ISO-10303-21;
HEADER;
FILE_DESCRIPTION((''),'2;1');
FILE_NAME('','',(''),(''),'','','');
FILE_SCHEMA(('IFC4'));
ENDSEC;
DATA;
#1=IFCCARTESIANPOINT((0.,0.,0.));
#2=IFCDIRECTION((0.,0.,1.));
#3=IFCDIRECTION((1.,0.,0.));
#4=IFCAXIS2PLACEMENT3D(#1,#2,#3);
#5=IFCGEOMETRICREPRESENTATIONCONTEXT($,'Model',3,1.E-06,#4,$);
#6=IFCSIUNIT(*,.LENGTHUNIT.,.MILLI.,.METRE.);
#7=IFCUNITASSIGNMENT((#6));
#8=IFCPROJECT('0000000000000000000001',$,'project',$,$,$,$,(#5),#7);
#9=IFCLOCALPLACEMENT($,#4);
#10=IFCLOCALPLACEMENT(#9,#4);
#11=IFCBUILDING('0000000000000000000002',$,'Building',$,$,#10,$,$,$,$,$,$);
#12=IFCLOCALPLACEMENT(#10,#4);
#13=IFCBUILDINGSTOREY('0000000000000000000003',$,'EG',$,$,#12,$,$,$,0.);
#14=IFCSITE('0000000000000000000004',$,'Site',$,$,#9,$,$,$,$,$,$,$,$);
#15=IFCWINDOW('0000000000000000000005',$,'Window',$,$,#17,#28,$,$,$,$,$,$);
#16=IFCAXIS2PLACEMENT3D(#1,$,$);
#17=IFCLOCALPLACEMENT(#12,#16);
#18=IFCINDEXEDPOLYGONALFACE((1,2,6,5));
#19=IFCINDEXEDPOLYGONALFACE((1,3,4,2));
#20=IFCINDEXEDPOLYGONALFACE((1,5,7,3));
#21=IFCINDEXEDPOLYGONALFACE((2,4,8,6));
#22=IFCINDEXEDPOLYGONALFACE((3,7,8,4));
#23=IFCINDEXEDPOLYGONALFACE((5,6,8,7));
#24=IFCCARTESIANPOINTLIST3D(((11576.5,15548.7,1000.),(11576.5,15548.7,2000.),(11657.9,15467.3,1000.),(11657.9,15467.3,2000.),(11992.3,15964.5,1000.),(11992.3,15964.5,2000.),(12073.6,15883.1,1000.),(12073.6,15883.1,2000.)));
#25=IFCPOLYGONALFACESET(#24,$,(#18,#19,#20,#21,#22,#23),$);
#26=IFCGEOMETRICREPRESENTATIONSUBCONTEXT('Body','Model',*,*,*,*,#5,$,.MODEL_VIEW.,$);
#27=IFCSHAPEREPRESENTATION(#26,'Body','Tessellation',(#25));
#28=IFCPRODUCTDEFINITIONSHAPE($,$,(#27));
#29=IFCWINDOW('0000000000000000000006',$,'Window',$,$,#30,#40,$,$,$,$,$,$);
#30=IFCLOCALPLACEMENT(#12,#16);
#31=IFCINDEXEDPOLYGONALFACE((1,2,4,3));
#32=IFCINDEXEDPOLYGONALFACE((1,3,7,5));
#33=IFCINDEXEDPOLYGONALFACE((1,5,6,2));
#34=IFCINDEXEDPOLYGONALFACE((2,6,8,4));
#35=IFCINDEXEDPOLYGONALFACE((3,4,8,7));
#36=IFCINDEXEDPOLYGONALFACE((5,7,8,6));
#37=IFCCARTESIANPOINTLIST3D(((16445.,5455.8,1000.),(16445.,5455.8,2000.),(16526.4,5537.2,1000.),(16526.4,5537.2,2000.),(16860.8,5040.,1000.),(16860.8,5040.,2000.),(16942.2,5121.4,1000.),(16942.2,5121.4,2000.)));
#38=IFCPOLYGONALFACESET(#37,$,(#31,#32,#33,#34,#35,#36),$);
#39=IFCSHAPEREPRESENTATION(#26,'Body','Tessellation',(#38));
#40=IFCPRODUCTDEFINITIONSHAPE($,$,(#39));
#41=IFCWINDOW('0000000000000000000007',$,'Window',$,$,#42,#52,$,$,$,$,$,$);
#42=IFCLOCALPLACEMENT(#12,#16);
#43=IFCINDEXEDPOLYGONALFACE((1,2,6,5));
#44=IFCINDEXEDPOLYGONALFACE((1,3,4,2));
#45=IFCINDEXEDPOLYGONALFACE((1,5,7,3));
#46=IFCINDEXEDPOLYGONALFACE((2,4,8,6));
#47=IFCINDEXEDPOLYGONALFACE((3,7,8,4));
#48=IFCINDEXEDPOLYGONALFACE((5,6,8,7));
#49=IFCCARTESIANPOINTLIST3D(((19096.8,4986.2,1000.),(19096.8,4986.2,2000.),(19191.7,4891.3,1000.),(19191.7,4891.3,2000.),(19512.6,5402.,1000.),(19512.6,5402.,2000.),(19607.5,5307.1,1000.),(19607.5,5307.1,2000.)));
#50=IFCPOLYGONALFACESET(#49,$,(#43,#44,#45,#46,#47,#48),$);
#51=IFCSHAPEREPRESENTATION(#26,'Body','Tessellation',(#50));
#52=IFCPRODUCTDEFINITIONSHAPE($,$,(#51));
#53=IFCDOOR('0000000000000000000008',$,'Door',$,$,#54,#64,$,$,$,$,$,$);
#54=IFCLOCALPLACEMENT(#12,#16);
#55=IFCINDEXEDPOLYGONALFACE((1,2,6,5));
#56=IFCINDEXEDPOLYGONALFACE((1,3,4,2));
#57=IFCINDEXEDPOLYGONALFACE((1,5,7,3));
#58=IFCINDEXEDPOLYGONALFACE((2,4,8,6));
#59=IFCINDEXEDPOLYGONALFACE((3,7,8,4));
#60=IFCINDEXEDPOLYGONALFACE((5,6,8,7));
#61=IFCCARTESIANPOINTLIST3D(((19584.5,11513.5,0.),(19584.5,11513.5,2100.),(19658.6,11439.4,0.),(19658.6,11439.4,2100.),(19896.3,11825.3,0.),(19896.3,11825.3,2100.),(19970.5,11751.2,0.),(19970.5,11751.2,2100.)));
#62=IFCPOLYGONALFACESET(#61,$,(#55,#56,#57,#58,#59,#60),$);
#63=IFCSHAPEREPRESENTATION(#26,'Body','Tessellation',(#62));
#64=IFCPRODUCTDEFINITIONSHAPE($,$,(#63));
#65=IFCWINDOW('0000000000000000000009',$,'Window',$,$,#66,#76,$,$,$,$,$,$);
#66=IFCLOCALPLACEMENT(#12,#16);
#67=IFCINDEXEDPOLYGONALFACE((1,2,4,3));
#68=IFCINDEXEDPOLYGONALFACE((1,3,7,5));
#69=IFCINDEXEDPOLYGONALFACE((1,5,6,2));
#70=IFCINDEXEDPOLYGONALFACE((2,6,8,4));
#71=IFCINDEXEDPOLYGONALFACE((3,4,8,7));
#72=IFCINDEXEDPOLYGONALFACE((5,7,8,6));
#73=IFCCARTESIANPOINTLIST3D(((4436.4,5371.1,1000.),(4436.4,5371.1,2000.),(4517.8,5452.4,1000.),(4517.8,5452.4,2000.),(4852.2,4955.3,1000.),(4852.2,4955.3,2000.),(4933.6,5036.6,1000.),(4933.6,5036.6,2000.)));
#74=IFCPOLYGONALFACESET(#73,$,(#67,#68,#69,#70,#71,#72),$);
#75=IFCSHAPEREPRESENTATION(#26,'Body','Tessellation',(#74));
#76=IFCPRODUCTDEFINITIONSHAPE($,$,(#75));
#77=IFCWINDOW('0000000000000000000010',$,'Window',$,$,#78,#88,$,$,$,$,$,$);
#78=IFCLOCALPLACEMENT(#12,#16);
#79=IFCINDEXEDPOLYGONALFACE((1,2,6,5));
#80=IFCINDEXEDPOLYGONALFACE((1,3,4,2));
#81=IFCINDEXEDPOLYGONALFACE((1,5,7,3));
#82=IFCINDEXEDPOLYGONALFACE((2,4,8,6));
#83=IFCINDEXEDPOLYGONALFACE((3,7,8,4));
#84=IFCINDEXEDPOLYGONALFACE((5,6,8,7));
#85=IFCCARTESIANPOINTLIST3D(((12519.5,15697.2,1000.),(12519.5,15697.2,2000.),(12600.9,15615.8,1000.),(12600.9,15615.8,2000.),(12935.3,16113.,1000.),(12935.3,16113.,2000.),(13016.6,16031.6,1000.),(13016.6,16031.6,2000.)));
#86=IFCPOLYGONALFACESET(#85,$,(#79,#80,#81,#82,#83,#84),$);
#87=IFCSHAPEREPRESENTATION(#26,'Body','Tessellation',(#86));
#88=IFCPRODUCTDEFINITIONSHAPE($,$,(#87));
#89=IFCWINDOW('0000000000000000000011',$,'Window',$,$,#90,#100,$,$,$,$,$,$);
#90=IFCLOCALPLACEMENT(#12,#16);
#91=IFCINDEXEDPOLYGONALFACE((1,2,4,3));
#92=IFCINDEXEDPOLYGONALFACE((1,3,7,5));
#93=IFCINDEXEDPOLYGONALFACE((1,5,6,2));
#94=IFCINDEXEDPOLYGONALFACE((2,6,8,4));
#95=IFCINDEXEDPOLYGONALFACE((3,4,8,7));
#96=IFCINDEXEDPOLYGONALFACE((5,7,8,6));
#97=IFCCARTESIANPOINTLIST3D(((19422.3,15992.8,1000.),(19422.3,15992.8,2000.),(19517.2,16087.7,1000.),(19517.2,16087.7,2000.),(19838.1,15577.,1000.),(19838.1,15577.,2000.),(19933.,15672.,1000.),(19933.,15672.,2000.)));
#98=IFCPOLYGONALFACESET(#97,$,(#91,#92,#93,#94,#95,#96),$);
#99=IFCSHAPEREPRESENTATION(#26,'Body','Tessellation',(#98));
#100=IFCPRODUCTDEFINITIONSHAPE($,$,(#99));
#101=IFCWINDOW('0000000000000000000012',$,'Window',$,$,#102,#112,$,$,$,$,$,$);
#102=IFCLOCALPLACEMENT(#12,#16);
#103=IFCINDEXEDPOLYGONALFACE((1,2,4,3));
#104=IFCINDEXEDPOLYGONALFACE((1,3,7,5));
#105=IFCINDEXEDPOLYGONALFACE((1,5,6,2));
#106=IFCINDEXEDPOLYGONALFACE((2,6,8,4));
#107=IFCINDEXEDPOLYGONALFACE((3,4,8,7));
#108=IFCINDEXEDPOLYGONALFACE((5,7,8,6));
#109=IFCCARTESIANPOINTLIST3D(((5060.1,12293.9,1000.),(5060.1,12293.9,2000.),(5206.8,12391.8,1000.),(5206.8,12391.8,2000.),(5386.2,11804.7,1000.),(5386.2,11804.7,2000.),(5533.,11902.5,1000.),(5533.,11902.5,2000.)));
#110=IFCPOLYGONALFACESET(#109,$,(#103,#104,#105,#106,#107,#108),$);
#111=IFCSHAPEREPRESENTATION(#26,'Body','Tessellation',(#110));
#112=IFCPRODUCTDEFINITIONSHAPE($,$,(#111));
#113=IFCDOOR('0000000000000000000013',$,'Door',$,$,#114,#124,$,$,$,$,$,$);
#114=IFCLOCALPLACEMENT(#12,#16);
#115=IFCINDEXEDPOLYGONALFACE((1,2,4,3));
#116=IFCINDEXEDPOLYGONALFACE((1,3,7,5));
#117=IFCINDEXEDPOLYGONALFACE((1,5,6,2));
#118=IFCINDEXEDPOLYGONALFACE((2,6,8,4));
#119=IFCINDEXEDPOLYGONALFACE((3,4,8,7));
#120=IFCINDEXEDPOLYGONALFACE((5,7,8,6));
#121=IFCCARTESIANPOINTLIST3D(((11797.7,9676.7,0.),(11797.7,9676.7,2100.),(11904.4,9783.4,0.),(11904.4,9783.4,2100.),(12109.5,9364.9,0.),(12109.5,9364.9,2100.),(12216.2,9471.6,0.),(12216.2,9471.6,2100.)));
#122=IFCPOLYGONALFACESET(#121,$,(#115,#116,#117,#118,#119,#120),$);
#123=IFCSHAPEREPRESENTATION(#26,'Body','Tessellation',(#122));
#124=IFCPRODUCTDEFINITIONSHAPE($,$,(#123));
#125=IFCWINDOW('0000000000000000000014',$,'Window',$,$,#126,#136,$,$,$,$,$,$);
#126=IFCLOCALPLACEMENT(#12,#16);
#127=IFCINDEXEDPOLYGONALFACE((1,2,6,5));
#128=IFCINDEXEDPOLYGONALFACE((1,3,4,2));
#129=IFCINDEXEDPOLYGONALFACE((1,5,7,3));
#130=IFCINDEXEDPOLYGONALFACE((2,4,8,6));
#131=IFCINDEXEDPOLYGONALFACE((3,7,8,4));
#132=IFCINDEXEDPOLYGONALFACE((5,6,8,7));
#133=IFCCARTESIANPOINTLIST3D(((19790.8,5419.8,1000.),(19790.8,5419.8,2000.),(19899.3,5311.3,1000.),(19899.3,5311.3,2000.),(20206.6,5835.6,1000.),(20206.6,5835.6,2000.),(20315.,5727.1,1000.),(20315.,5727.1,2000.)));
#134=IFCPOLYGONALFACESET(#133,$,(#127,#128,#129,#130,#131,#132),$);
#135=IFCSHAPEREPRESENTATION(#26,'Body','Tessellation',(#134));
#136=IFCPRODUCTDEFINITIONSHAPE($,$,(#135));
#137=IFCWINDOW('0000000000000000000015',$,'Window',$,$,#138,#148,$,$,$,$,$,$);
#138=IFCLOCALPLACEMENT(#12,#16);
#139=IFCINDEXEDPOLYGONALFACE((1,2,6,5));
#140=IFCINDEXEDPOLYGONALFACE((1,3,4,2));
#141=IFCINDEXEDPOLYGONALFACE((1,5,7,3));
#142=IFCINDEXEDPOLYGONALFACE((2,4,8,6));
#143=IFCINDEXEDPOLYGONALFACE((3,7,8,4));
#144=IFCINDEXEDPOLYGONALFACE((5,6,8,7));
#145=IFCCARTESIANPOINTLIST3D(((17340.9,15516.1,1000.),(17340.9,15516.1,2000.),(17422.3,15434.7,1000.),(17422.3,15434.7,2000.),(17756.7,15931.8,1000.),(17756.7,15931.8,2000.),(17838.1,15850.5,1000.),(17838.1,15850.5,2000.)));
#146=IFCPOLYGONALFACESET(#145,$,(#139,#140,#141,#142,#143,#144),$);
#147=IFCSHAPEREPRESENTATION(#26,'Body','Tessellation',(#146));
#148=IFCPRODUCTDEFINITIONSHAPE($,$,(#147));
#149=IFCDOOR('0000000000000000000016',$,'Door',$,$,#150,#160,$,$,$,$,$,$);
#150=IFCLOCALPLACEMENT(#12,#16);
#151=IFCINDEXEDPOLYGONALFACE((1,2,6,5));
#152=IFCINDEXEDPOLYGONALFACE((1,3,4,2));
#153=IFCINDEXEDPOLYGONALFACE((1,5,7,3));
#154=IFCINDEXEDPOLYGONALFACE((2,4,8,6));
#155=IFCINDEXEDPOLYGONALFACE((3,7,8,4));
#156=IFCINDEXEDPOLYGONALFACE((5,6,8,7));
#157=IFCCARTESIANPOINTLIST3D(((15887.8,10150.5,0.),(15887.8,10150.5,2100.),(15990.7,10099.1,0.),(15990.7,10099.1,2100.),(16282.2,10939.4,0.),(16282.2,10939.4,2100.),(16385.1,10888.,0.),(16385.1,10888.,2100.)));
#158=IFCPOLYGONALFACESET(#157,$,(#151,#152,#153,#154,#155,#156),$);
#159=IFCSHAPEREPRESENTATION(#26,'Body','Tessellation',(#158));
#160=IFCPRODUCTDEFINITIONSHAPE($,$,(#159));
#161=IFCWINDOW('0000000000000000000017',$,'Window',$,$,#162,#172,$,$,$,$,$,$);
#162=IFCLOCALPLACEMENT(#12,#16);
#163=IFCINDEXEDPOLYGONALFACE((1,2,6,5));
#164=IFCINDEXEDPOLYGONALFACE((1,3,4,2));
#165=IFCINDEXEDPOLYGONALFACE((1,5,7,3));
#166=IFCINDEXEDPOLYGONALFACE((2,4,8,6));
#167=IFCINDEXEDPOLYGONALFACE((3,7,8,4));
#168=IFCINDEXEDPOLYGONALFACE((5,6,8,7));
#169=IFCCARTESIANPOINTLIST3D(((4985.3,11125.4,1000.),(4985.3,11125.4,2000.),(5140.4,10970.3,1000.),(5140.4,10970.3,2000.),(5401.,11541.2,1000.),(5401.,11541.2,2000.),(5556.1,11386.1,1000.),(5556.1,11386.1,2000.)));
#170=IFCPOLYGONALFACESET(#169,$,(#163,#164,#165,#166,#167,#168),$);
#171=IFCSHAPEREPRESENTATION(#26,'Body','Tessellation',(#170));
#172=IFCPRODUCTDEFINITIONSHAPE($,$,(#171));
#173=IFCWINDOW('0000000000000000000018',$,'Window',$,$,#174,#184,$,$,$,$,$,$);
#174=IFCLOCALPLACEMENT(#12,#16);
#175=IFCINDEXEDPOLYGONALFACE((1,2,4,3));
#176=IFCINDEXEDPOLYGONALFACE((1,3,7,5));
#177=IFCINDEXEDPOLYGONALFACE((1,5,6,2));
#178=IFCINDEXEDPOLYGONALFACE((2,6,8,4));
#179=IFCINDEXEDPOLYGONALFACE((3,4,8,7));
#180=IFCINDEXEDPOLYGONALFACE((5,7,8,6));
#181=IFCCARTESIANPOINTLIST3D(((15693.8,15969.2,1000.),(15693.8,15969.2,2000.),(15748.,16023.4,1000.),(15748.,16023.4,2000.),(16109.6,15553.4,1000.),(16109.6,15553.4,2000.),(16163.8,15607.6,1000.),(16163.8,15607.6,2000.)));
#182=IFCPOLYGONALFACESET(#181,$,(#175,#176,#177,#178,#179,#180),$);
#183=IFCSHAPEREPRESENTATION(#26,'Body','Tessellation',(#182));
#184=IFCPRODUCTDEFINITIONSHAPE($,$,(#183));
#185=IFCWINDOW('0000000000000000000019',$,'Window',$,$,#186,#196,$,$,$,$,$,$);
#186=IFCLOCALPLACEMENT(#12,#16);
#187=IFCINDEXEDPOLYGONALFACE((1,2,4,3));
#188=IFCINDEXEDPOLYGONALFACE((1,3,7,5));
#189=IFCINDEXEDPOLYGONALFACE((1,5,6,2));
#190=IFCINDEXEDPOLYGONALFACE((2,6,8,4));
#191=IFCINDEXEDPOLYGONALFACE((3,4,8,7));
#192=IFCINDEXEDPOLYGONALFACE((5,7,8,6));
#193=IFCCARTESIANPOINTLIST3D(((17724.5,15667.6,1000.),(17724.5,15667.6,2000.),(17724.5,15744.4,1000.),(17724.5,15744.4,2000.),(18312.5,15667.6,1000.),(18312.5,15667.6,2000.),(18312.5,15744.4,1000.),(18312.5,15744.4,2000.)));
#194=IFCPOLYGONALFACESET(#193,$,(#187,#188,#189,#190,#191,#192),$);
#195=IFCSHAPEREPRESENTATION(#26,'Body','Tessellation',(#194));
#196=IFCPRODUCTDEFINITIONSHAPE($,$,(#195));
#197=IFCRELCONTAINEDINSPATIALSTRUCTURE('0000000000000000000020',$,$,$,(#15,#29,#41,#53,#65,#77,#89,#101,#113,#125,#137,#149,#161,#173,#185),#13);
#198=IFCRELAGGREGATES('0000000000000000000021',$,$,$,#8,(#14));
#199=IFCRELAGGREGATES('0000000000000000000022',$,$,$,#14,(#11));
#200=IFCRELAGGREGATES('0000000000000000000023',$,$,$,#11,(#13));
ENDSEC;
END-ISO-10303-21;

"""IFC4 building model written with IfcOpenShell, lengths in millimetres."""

from ifc_helpers import new_model, si_unit, frame, origin_with_axes, place, context, subcontext, project, spatial, rectangle, extrude, element, save


model = new_model("IFC4")

# Units and contexts
model_context = context("Model", 3, precision=1e-06, world=origin_with_axes())
body_context = subcontext(model_context, "Body", "Model", "MODEL_VIEW")
ifc_project = project(units=[si_unit("LENGTHUNIT", "METRE", prefix="MILLI")], contexts=[model_context])

# Site, building, storey
site_placement = place(None, origin_with_axes())
site = spatial("IfcSite", under=ifc_project, at=site_placement, Name="Site")
building_placement = place(site_placement, origin_with_axes())
building = spatial("IfcBuilding", under=site, at=building_placement, Name="Building")
storey_placement = place(building_placement, origin_with_axes())
storey = spatial("IfcBuildingStorey", under=building, at=storey_placement, Name="EG", Elevation=0.0)

# Windows
window_1_placement = place(storey_placement, origin_with_axes())
element("IfcWindow", 1, at=window_1_placement, inside=storey, Name="Window", context=body_context, shape_type="SweptSolid", body=[
    extrude(rectangle(XDim=588.0, YDim=115.1), frame((11825.1, 15715.9, 1000.0), z_axis=(0.0, 0.0, 1.0), x_axis=(-0.707107, -0.707107, 0.0)), (0.0, 0.0, 1.0), 1000.0),
])
window_2_placement = place(storey_placement, origin_with_axes())
element("IfcWindow", 2, at=window_2_placement, inside=storey, Name="Window", context=body_context, shape_type="SweptSolid", body=[
    extrude(rectangle(XDim=588.0, YDim=115.1), frame((16693.6, 5288.6, 1000.0), z_axis=(0.0, 0.0, 1.0), x_axis=(-0.707107, 0.707107, 0.0)), (0.0, 0.0, 1.0), 1000.0),
])
window_3_placement = place(storey_placement, origin_with_axes())
element("IfcWindow", 3, at=window_3_placement, inside=storey, Name="Window", context=body_context, shape_type="SweptSolid", body=[
    extrude(rectangle(XDim=588.0, YDim=134.2), frame((19352.1, 5146.7, 1000.0), z_axis=(0.0, 0.0, 1.0), x_axis=(-0.707107, -0.707107, 0.0)), (0.0, 0.0, 1.0), 1000.0),
])

# Door
door_1_placement = place(storey_placement, origin_with_axes())
element("IfcDoor", 4, at=door_1_placement, inside=storey, Name="Door", context=body_context, shape_type="SweptSolid", body=[
    extrude(rectangle(XDim=441.0, YDim=104.8), frame((19777.5, 11632.4, 0.0), z_axis=(0.0, 0.0, 1.0), x_axis=(0.707107, 0.707107, 0.0)), (0.0, 0.0, 1.0), 2100.0),
])

# Windows
window_4_placement = place(storey_placement, origin_with_axes())
element("IfcWindow", 5, at=window_4_placement, inside=storey, Name="Window", context=body_context, shape_type="SweptSolid", body=[
    extrude(rectangle(XDim=588.0, YDim=115.1), frame((4685.0, 5203.9, 1000.0), z_axis=(0.0, 0.0, 1.0), x_axis=(0.707107, -0.707107, 0.0)), (0.0, 0.0, 1.0), 1000.0),
])
window_5_placement = place(storey_placement, origin_with_axes())
element("IfcWindow", 6, at=window_5_placement, inside=storey, Name="Window", context=body_context, shape_type="SweptSolid", body=[
    extrude(rectangle(XDim=588.0, YDim=115.1), frame((12768.1, 15864.4, 1000.0), z_axis=(0.0, 0.0, 1.0), x_axis=(0.707107, 0.707107, 0.0)), (0.0, 0.0, 1.0), 1000.0),
])
window_6_placement = place(storey_placement, origin_with_axes())
element("IfcWindow", 7, at=window_6_placement, inside=storey, Name="Window", context=body_context, shape_type="SweptSolid", body=[
    extrude(rectangle(XDim=588.0, YDim=134.2), frame((19677.6, 15832.4, 1000.0), z_axis=(0.0, 0.0, 1.0), x_axis=(-0.707107, 0.707107, 0.0)), (0.0, 0.0, 1.0), 1000.0),
])
window_7_placement = place(storey_placement, origin_with_axes())
element("IfcWindow", 8, at=window_7_placement, inside=storey, Name="Window", context=body_context, shape_type="SweptSolid", body=[
    extrude(rectangle(XDim=588.0, YDim=176.4), frame((5296.5, 12098.2, 1000.0), z_axis=(0.0, 0.0, 1.0), x_axis=(-0.5547, 0.83205, 0.0)), (0.0, 0.0, 1.0), 1000.0),
])

# Door
door_2_placement = place(storey_placement, origin_with_axes())
element("IfcDoor", 9, at=door_2_placement, inside=storey, Name="Door", context=body_context, shape_type="SweptSolid", body=[
    extrude(rectangle(XDim=441.0, YDim=150.9), frame((12006.9, 9574.1, 0.0), z_axis=(0.0, 0.0, 1.0), x_axis=(0.707107, -0.707107, 0.0)), (0.0, 0.0, 1.0), 2100.0),
])

# Windows
window_8_placement = place(storey_placement, origin_with_axes())
element("IfcWindow", 10, at=window_8_placement, inside=storey, Name="Window", context=body_context, shape_type="SweptSolid", body=[
    extrude(rectangle(XDim=588.0, YDim=153.4), frame((20052.9, 5573.5, 1000.0), z_axis=(0.0, 0.0, 1.0), x_axis=(-0.707107, -0.707107, 0.0)), (0.0, 0.0, 1.0), 1000.0),
])
window_9_placement = place(storey_placement, origin_with_axes())
element("IfcWindow", 11, at=window_9_placement, inside=storey, Name="Window", context=body_context, shape_type="SweptSolid", body=[
    extrude(rectangle(XDim=588.0, YDim=115.1), frame((17589.5, 15683.3, 1000.0), z_axis=(0.0, 0.0, 1.0), x_axis=(-0.707107, -0.707107, 0.0)), (0.0, 0.0, 1.0), 1000.0),
])

# Door
door_3_placement = place(storey_placement, origin_with_axes())
element("IfcDoor", 12, at=door_3_placement, inside=storey, Name="Door", context=body_context, shape_type="SweptSolid", body=[
    extrude(rectangle(XDim=882.0, YDim=115.0), frame((16136.4, 10519.2, 0.0), z_axis=(0.0, 0.0, 1.0), x_axis=(0.447214, 0.894427, 0.0)), (0.0, 0.0, 1.0), 2100.0),
])

# Windows
window_10_placement = place(storey_placement, origin_with_axes())
element("IfcWindow", 13, at=window_10_placement, inside=storey, Name="Window", context=body_context, shape_type="SweptSolid", body=[
    extrude(rectangle(XDim=588.0, YDim=219.3), frame((5270.7, 11255.7, 1000.0), z_axis=(0.0, 0.0, 1.0), x_axis=(-0.707107, -0.707107, 0.0)), (0.0, 0.0, 1.0), 1000.0),
])
window_11_placement = place(storey_placement, origin_with_axes())
element("IfcWindow", 14, at=window_11_placement, inside=storey, Name="Window", context=body_context, shape_type="SweptSolid", body=[
    extrude(rectangle(XDim=588.0, YDim=76.7), frame((15928.8, 15788.4, 1000.0), z_axis=(0.0, 0.0, 1.0), x_axis=(-0.707107, 0.707107, 0.0)), (0.0, 0.0, 1.0), 1000.0),
])
window_12_placement = place(storey_placement, origin_with_axes())
element("IfcWindow", 15, at=window_12_placement, inside=storey, Name="Window", context=body_context, shape_type="SweptSolid", body=[
    extrude(rectangle(XDim=588.0, YDim=76.7), frame((18018.5, 15706.0, 1000.0), z_axis=(0.0, 0.0, 1.0), x_axis=(1.0, 0.0, 0.0)), (0.0, 0.0, 1.0), 1000.0),
])

save(model, "model.ifc")
